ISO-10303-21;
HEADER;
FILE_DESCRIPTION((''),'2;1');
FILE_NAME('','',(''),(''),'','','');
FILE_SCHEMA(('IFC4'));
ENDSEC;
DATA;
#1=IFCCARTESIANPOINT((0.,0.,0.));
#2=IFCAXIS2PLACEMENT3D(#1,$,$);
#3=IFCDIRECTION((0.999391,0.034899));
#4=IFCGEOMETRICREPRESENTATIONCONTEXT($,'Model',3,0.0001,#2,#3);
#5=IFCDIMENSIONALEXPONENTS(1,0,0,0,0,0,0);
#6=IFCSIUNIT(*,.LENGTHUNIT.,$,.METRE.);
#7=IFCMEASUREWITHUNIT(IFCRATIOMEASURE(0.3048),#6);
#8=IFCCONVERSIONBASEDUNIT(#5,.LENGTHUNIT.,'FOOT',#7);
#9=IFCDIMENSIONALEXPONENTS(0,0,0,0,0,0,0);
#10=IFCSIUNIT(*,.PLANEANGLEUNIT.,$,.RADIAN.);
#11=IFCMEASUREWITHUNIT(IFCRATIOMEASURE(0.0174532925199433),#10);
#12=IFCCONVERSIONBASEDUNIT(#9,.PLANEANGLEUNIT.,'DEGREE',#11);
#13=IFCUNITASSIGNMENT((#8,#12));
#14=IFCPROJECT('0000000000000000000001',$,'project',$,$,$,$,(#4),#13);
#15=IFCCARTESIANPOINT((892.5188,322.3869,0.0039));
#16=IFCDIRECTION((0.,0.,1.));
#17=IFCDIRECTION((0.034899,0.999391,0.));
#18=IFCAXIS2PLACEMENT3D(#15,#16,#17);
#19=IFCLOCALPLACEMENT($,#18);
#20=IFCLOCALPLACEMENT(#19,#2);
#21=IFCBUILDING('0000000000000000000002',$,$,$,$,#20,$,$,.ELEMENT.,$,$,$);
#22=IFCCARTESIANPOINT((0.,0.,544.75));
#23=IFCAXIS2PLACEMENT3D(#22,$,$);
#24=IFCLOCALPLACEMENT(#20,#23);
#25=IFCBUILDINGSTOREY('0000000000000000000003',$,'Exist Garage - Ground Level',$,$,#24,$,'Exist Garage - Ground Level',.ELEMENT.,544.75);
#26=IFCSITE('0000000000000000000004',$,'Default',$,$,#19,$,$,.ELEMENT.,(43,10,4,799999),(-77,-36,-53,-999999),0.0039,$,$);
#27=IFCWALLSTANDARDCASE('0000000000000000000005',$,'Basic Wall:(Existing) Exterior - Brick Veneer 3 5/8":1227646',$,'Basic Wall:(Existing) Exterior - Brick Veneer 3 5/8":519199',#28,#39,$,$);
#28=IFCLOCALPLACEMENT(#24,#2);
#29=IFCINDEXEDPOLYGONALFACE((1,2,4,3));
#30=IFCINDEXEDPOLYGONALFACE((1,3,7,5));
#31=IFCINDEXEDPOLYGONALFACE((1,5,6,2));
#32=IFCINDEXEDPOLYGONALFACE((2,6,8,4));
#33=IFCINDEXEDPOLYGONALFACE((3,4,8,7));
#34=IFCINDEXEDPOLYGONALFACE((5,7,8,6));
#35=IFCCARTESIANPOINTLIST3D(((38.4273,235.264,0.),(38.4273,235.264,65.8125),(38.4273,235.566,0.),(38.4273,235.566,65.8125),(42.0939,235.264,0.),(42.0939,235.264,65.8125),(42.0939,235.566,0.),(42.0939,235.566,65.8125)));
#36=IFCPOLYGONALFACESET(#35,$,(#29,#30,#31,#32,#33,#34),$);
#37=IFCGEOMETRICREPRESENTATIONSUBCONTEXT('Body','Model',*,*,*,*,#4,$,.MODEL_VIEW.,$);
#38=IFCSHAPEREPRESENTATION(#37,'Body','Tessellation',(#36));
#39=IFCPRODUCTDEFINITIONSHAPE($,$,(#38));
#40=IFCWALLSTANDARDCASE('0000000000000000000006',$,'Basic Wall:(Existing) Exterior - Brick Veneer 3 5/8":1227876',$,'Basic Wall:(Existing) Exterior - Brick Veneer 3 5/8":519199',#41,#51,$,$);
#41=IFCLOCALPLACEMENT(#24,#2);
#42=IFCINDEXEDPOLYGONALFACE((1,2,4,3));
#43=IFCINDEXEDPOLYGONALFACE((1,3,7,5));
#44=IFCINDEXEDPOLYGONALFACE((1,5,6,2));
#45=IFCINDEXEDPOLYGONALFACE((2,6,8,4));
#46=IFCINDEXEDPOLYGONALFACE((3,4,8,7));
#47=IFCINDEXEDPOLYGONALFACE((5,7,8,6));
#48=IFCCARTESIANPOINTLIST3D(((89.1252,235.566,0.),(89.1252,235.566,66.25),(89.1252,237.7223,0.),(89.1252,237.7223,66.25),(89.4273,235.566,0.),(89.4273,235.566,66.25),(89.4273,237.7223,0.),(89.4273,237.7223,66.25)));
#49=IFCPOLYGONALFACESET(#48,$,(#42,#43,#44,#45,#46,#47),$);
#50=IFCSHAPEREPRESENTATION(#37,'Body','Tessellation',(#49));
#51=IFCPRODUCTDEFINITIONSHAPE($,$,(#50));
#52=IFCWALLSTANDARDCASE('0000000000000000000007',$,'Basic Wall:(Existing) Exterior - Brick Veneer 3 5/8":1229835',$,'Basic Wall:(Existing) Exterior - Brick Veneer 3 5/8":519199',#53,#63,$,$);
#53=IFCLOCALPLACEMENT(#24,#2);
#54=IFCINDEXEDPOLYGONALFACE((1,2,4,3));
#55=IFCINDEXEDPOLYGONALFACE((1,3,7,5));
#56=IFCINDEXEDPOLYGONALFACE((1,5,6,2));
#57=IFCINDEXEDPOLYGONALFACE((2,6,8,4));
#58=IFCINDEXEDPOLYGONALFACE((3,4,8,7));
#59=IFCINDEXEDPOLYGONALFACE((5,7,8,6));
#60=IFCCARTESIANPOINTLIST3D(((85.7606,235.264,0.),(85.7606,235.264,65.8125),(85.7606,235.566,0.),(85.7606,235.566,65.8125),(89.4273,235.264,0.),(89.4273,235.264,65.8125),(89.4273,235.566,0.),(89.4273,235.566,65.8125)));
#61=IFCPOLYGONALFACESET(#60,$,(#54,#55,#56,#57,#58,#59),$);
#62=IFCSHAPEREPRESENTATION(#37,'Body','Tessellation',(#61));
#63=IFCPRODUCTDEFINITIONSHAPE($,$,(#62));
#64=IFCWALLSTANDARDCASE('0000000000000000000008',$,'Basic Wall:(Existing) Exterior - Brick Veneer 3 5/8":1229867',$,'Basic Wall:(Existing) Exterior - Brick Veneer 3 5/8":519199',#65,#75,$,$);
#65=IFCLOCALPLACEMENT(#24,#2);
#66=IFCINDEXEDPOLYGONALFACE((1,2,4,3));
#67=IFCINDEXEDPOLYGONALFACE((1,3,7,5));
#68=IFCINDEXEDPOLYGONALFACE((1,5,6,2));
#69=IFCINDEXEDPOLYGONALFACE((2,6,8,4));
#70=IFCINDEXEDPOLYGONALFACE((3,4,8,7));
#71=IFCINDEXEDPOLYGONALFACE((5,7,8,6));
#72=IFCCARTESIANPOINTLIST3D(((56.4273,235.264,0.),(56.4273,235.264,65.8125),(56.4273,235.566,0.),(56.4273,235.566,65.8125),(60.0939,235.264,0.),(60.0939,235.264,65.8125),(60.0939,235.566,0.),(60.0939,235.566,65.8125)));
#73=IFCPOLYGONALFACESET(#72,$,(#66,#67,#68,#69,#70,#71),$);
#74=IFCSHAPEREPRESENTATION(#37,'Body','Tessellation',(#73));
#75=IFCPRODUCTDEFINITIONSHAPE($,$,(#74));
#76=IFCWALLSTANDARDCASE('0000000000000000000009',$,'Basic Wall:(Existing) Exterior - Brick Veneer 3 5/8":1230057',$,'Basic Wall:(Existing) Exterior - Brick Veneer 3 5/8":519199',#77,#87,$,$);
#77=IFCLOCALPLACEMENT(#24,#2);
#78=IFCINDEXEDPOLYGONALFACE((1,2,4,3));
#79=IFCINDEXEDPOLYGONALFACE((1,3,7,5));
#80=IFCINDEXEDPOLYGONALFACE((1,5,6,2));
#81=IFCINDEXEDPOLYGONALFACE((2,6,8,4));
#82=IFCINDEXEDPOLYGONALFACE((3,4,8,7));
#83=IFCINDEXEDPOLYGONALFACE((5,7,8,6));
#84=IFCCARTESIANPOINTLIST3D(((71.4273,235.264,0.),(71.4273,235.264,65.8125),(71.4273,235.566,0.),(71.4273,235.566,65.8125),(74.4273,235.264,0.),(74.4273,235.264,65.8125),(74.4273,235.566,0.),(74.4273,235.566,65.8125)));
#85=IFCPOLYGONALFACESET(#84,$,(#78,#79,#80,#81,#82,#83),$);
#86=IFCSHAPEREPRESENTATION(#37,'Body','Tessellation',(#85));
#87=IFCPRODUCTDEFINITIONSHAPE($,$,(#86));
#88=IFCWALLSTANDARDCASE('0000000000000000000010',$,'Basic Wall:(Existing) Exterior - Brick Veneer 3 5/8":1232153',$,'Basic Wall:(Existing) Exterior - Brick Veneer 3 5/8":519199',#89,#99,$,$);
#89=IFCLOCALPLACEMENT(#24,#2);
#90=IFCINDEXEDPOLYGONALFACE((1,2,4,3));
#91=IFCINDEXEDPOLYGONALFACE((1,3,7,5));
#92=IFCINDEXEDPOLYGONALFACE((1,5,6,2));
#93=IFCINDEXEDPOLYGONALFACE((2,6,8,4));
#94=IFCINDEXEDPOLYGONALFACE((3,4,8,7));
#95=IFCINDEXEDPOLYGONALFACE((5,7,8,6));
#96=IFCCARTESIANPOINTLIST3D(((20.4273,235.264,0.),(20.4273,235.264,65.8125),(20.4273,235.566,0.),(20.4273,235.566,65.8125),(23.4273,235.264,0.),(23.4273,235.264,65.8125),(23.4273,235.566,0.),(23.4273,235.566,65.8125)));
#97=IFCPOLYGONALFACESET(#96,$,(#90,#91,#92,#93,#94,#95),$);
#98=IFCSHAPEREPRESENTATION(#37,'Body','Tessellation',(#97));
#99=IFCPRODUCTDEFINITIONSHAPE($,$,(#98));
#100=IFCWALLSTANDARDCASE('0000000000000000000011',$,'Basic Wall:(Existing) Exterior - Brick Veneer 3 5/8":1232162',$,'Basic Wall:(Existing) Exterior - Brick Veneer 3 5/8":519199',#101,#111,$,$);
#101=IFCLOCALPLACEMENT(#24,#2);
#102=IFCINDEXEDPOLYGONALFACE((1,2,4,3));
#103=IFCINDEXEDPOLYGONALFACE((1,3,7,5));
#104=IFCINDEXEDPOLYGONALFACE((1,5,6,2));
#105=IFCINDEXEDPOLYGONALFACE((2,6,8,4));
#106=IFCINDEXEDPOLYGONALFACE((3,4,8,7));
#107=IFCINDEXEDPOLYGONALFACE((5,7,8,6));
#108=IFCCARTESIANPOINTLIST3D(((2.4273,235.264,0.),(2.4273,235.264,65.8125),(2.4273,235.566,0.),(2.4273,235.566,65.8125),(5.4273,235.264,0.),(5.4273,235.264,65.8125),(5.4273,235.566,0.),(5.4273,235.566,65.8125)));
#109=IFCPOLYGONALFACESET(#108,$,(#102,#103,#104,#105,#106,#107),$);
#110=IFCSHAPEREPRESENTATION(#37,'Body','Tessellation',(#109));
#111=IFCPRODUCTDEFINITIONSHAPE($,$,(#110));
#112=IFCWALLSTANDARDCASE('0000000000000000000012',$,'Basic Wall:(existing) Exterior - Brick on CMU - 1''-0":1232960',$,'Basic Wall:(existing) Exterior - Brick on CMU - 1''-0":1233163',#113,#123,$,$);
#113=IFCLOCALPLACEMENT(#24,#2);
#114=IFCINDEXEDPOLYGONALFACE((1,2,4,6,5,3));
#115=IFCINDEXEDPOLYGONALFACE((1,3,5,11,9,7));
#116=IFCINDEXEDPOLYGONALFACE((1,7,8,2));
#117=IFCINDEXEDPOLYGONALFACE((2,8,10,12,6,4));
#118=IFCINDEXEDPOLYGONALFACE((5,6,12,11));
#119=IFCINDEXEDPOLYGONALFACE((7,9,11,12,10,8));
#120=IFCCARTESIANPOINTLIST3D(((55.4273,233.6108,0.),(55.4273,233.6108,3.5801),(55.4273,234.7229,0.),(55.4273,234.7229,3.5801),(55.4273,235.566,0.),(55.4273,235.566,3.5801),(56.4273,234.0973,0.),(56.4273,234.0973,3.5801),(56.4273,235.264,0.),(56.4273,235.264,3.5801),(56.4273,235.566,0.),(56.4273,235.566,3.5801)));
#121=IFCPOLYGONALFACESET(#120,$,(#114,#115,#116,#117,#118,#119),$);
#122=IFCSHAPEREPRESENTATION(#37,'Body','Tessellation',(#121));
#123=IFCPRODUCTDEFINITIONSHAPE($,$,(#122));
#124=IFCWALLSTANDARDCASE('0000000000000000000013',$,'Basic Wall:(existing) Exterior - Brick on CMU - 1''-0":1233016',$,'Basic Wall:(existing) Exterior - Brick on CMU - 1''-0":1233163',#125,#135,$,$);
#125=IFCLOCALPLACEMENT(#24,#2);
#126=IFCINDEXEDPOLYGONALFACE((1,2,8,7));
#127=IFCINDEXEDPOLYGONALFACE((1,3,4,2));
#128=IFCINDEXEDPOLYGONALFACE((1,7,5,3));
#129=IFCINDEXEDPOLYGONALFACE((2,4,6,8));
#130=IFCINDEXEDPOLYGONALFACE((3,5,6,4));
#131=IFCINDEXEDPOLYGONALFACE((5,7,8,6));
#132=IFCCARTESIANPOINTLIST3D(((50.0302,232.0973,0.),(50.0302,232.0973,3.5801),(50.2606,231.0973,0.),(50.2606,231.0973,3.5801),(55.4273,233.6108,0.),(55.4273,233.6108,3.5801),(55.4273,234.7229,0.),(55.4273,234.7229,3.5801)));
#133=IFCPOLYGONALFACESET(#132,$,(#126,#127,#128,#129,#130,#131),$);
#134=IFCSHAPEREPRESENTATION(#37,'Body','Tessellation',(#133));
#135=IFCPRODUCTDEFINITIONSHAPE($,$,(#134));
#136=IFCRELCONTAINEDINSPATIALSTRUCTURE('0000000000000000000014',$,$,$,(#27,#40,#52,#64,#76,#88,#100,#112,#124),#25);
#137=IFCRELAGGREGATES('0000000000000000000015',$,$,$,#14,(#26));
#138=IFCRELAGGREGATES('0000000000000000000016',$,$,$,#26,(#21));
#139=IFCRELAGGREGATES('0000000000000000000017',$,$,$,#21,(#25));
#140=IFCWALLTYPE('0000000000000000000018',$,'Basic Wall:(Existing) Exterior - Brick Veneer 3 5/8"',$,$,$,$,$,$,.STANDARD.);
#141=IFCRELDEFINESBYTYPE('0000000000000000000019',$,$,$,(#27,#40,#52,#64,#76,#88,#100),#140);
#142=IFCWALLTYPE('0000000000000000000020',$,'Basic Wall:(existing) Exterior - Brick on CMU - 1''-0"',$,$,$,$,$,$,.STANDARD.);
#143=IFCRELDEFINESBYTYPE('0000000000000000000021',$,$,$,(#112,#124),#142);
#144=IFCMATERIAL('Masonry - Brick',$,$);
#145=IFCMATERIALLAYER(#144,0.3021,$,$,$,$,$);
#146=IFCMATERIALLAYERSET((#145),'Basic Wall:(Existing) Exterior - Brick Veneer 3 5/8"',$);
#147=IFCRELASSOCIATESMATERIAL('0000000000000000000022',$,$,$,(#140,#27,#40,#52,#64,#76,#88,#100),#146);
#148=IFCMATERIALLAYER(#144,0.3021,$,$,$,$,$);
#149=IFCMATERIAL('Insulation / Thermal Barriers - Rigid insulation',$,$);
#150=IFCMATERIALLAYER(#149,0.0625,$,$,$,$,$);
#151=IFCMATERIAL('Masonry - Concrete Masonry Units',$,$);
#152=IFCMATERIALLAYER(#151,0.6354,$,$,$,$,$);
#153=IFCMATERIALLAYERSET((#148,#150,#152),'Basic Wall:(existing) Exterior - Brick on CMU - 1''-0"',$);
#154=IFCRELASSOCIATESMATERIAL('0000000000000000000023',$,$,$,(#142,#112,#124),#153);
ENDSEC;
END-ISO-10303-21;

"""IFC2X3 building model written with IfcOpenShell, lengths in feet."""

from ifc_helpers import new_model, entity, si_unit, converted_unit, direction, frame, frame_2d, origin, place, context, subcontext, project, spatial, polyline, rectangle, outline, extrude, material, layer, layer_set, layer_usage, type_object, element, save


model = new_model("IFC2X3")

# Units and contexts
model_context = context("Model", 3, precision=0.0001, world=origin(), true_north=direction((0.999391, 0.034899)))
body_context = subcontext(model_context, "Body", "Model", "MODEL_VIEW")
ifc_project = project(units=[converted_unit("LENGTHUNIT", "FOOT", entity("IfcRatioMeasure", 0.3048), si_unit("LENGTHUNIT", "METRE"), dimensions=[1, 0, 0, 0, 0, 0, 0]), converted_unit("PLANEANGLEUNIT", "DEGREE", entity("IfcRatioMeasure", 0.0174532925199433), si_unit("PLANEANGLEUNIT", "RADIAN"), dimensions=[0, 0, 0, 0, 0, 0, 0])], contexts=[model_context])

# Site, building, storey
site_placement = place(None, frame((892.5188, 322.3869, 0.0039), z_axis=(0.0, 0.0, 1.0), x_axis=(0.034899, 0.999391, 0.0)))
site = spatial("IfcSite", under=ifc_project, at=site_placement, Name="Default", CompositionType="ELEMENT", RefLatitude=(43, 10, 4, 799999), RefLongitude=(-77, -36, -53, -999999), RefElevation=0.0039)
building_placement = place(site_placement, origin())
building = spatial("IfcBuilding", under=site, at=building_placement, CompositionType="ELEMENT")
storey_placement = place(building_placement, frame((0.0, 0.0, 544.75)))
storey = spatial("IfcBuildingStorey", under=building, at=storey_placement, Name="Exist Garage - Ground Level", LongName="Exist Garage - Ground Level", CompositionType="ELEMENT", Elevation=544.75)

# Walls
ifc_material_1 = material(Name="Masonry - Brick")
ifc_layer_1 = layer(ifc_material_1, 0.3021)
ifc_layer_set_1 = layer_set([ifc_layer_1], Name="Basic Wall:(Existing) Exterior - Brick Veneer 3 5/8\"")
ifc_layer_usage_1 = layer_usage(ifc_layer_set_1, "AXIS2", "POSITIVE", -0.151)
wall_type_1 = type_object("IfcWallType", Name="Basic Wall:(Existing) Exterior - Brick Veneer 3 5/8\"", PredefinedType="STANDARD", material=ifc_layer_set_1)
wall_1_placement = place(storey_placement, frame((38.4273, 235.415, 0.0)))
element("IfcWallStandardCase", 1, at=wall_1_placement, inside=storey, type_object=wall_type_1, material=ifc_layer_usage_1, Name="Basic Wall:(Existing) Exterior - Brick Veneer 3 5/8\":1227646", ObjectType="Basic Wall:(Existing) Exterior - Brick Veneer 3 5/8\":519199", context=body_context, shape_type="SweptSolid", body=[
    extrude(rectangle(XDim=3.6667, YDim=0.3021, at=frame_2d((1.8333, 0.0), x_axis=(-1.0, 0.0))), origin(), (0.0, 0.0, 1.0), 65.8125),
])
ifc_layer_usage_2 = layer_usage(ifc_layer_set_1, "AXIS2", "POSITIVE", -0.151)
wall_2_placement = place(storey_placement, frame((89.2763, 235.566, 0.0), z_axis=(0.0, 0.0, 1.0), x_axis=(0.0, 1.0, 0.0)))
element("IfcWallStandardCase", 2, at=wall_2_placement, inside=storey, type_object=wall_type_1, material=ifc_layer_usage_2, Name="Basic Wall:(Existing) Exterior - Brick Veneer 3 5/8\":1227876", ObjectType="Basic Wall:(Existing) Exterior - Brick Veneer 3 5/8\":519199", context=body_context, shape_type="SweptSolid", body=[
    extrude(rectangle(XDim=2.1563, YDim=0.3021, at=frame_2d((1.0781, 0.0), x_axis=(-1.0, 0.0))), origin(), (0.0, 0.0, 1.0), 66.25),
])
ifc_layer_usage_3 = layer_usage(ifc_layer_set_1, "AXIS2", "POSITIVE", -0.151)
wall_3_placement = place(storey_placement, frame((85.7606, 235.415, 0.0)))
element("IfcWallStandardCase", 3, at=wall_3_placement, inside=storey, type_object=wall_type_1, material=ifc_layer_usage_3, Name="Basic Wall:(Existing) Exterior - Brick Veneer 3 5/8\":1229835", ObjectType="Basic Wall:(Existing) Exterior - Brick Veneer 3 5/8\":519199", context=body_context, shape_type="SweptSolid", body=[
    extrude(rectangle(XDim=3.6667, YDim=0.3021, at=frame_2d((1.8333, 0.0), x_axis=(-1.0, 0.0))), origin(), (0.0, 0.0, 1.0), 65.8125),
])
ifc_layer_usage_4 = layer_usage(ifc_layer_set_1, "AXIS2", "POSITIVE", -0.151)
wall_4_placement = place(storey_placement, frame((56.4273, 235.415, 0.0)))
element("IfcWallStandardCase", 4, at=wall_4_placement, inside=storey, type_object=wall_type_1, material=ifc_layer_usage_4, Name="Basic Wall:(Existing) Exterior - Brick Veneer 3 5/8\":1229867", ObjectType="Basic Wall:(Existing) Exterior - Brick Veneer 3 5/8\":519199", context=body_context, shape_type="SweptSolid", body=[
    extrude(rectangle(XDim=3.6667, YDim=0.3021, at=frame_2d((1.8333, 0.0), x_axis=(-1.0, 0.0))), origin(), (0.0, 0.0, 1.0), 65.8125),
])
ifc_layer_usage_5 = layer_usage(ifc_layer_set_1, "AXIS2", "POSITIVE", -0.151)
wall_5_placement = place(storey_placement, frame((71.4273, 235.415, 0.0)))
element("IfcWallStandardCase", 5, at=wall_5_placement, inside=storey, type_object=wall_type_1, material=ifc_layer_usage_5, Name="Basic Wall:(Existing) Exterior - Brick Veneer 3 5/8\":1230057", ObjectType="Basic Wall:(Existing) Exterior - Brick Veneer 3 5/8\":519199", context=body_context, shape_type="SweptSolid", body=[
    extrude(rectangle(XDim=3.0, YDim=0.3021, at=frame_2d((1.5, 0.0), x_axis=(-1.0, 0.0))), origin(), (0.0, 0.0, 1.0), 65.8125),
])
ifc_layer_usage_6 = layer_usage(ifc_layer_set_1, "AXIS2", "POSITIVE", -0.151)
wall_6_placement = place(storey_placement, frame((20.4273, 235.415, 0.0)))
element("IfcWallStandardCase", 6, at=wall_6_placement, inside=storey, type_object=wall_type_1, material=ifc_layer_usage_6, Name="Basic Wall:(Existing) Exterior - Brick Veneer 3 5/8\":1232153", ObjectType="Basic Wall:(Existing) Exterior - Brick Veneer 3 5/8\":519199", context=body_context, shape_type="SweptSolid", body=[
    extrude(rectangle(XDim=3.0, YDim=0.3021, at=frame_2d((1.5, 0.0), x_axis=(-1.0, 0.0))), origin(), (0.0, 0.0, 1.0), 65.8125),
])
ifc_layer_usage_7 = layer_usage(ifc_layer_set_1, "AXIS2", "POSITIVE", -0.151)
wall_7_placement = place(storey_placement, frame((2.4273, 235.415, 0.0)))
element("IfcWallStandardCase", 7, at=wall_7_placement, inside=storey, type_object=wall_type_1, material=ifc_layer_usage_7, Name="Basic Wall:(Existing) Exterior - Brick Veneer 3 5/8\":1232162", ObjectType="Basic Wall:(Existing) Exterior - Brick Veneer 3 5/8\":519199", context=body_context, shape_type="SweptSolid", body=[
    extrude(rectangle(XDim=3.0, YDim=0.3021, at=frame_2d((1.5, 0.0), x_axis=(-1.0, 0.0))), origin(), (0.0, 0.0, 1.0), 65.8125),
])
ifc_layer_2 = layer(ifc_material_1, 0.3021)
ifc_material_2 = material(Name="Insulation / Thermal Barriers - Rigid insulation")
ifc_layer_3 = layer(ifc_material_2, 0.0625)
ifc_material_3 = material(Name="Masonry - Concrete Masonry Units")
ifc_layer_4 = layer(ifc_material_3, 0.6354)
ifc_layer_set_2 = layer_set([ifc_layer_2, ifc_layer_3, ifc_layer_4], Name="Basic Wall:(existing) Exterior - Brick on CMU - 1'-0\"")
ifc_layer_usage_8 = layer_usage(ifc_layer_set_2, "AXIS2", "NEGATIVE", 0.5)
wall_type_2 = type_object("IfcWallType", Name="Basic Wall:(existing) Exterior - Brick on CMU - 1'-0\"", PredefinedType="STANDARD", material=ifc_layer_set_2)
wall_8_placement = place(storey_placement, frame((55.9273, 235.566, 0.0), z_axis=(0.0, 0.0, 1.0), x_axis=(0.0, -1.0, 0.0)))
element("IfcWallStandardCase", 8, at=wall_8_placement, inside=storey, type_object=wall_type_2, material=ifc_layer_usage_8, Name="Basic Wall:(existing) Exterior - Brick on CMU - 1'-0\":1232960", ObjectType="Basic Wall:(existing) Exterior - Brick on CMU - 1'-0\":1233163", context=body_context, shape_type="SweptSolid", body=[
    extrude(outline(polyline([(1.9552, -0.5), (1.4687, 0.5), (0.3021, 0.5), (0.0, 0.5), (0.0, -0.5), (0.8432, -0.5), (1.9552, -0.5)])), origin(), (0.0, 0.0, 1.0), 3.5801),
])
ifc_layer_usage_9 = layer_usage(ifc_layer_set_2, "AXIS2", "NEGATIVE", 0.5)
wall_9_placement = place(storey_placement, frame((55.646, 234.2732, 0.0), z_axis=(0.0, 0.0, 1.0), x_axis=(-0.899235, -0.437466, 0.0)))
element("IfcWallStandardCase", 9, at=wall_9_placement, inside=storey, type_object=wall_type_2, material=ifc_layer_usage_9, Name="Basic Wall:(existing) Exterior - Brick on CMU - 1'-0\":1233016", ObjectType="Basic Wall:(existing) Exterior - Brick on CMU - 1'-0\":1233163", context=body_context, shape_type="SweptSolid", body=[
    extrude(outline(polyline([(6.0018, -0.5), (6.2321, 0.5), (0.4865, 0.5), (0.0, -0.5), (6.0018, -0.5)])), origin(), (0.0, 0.0, 1.0), 3.5801),
])

save(model, "model.ifc")
